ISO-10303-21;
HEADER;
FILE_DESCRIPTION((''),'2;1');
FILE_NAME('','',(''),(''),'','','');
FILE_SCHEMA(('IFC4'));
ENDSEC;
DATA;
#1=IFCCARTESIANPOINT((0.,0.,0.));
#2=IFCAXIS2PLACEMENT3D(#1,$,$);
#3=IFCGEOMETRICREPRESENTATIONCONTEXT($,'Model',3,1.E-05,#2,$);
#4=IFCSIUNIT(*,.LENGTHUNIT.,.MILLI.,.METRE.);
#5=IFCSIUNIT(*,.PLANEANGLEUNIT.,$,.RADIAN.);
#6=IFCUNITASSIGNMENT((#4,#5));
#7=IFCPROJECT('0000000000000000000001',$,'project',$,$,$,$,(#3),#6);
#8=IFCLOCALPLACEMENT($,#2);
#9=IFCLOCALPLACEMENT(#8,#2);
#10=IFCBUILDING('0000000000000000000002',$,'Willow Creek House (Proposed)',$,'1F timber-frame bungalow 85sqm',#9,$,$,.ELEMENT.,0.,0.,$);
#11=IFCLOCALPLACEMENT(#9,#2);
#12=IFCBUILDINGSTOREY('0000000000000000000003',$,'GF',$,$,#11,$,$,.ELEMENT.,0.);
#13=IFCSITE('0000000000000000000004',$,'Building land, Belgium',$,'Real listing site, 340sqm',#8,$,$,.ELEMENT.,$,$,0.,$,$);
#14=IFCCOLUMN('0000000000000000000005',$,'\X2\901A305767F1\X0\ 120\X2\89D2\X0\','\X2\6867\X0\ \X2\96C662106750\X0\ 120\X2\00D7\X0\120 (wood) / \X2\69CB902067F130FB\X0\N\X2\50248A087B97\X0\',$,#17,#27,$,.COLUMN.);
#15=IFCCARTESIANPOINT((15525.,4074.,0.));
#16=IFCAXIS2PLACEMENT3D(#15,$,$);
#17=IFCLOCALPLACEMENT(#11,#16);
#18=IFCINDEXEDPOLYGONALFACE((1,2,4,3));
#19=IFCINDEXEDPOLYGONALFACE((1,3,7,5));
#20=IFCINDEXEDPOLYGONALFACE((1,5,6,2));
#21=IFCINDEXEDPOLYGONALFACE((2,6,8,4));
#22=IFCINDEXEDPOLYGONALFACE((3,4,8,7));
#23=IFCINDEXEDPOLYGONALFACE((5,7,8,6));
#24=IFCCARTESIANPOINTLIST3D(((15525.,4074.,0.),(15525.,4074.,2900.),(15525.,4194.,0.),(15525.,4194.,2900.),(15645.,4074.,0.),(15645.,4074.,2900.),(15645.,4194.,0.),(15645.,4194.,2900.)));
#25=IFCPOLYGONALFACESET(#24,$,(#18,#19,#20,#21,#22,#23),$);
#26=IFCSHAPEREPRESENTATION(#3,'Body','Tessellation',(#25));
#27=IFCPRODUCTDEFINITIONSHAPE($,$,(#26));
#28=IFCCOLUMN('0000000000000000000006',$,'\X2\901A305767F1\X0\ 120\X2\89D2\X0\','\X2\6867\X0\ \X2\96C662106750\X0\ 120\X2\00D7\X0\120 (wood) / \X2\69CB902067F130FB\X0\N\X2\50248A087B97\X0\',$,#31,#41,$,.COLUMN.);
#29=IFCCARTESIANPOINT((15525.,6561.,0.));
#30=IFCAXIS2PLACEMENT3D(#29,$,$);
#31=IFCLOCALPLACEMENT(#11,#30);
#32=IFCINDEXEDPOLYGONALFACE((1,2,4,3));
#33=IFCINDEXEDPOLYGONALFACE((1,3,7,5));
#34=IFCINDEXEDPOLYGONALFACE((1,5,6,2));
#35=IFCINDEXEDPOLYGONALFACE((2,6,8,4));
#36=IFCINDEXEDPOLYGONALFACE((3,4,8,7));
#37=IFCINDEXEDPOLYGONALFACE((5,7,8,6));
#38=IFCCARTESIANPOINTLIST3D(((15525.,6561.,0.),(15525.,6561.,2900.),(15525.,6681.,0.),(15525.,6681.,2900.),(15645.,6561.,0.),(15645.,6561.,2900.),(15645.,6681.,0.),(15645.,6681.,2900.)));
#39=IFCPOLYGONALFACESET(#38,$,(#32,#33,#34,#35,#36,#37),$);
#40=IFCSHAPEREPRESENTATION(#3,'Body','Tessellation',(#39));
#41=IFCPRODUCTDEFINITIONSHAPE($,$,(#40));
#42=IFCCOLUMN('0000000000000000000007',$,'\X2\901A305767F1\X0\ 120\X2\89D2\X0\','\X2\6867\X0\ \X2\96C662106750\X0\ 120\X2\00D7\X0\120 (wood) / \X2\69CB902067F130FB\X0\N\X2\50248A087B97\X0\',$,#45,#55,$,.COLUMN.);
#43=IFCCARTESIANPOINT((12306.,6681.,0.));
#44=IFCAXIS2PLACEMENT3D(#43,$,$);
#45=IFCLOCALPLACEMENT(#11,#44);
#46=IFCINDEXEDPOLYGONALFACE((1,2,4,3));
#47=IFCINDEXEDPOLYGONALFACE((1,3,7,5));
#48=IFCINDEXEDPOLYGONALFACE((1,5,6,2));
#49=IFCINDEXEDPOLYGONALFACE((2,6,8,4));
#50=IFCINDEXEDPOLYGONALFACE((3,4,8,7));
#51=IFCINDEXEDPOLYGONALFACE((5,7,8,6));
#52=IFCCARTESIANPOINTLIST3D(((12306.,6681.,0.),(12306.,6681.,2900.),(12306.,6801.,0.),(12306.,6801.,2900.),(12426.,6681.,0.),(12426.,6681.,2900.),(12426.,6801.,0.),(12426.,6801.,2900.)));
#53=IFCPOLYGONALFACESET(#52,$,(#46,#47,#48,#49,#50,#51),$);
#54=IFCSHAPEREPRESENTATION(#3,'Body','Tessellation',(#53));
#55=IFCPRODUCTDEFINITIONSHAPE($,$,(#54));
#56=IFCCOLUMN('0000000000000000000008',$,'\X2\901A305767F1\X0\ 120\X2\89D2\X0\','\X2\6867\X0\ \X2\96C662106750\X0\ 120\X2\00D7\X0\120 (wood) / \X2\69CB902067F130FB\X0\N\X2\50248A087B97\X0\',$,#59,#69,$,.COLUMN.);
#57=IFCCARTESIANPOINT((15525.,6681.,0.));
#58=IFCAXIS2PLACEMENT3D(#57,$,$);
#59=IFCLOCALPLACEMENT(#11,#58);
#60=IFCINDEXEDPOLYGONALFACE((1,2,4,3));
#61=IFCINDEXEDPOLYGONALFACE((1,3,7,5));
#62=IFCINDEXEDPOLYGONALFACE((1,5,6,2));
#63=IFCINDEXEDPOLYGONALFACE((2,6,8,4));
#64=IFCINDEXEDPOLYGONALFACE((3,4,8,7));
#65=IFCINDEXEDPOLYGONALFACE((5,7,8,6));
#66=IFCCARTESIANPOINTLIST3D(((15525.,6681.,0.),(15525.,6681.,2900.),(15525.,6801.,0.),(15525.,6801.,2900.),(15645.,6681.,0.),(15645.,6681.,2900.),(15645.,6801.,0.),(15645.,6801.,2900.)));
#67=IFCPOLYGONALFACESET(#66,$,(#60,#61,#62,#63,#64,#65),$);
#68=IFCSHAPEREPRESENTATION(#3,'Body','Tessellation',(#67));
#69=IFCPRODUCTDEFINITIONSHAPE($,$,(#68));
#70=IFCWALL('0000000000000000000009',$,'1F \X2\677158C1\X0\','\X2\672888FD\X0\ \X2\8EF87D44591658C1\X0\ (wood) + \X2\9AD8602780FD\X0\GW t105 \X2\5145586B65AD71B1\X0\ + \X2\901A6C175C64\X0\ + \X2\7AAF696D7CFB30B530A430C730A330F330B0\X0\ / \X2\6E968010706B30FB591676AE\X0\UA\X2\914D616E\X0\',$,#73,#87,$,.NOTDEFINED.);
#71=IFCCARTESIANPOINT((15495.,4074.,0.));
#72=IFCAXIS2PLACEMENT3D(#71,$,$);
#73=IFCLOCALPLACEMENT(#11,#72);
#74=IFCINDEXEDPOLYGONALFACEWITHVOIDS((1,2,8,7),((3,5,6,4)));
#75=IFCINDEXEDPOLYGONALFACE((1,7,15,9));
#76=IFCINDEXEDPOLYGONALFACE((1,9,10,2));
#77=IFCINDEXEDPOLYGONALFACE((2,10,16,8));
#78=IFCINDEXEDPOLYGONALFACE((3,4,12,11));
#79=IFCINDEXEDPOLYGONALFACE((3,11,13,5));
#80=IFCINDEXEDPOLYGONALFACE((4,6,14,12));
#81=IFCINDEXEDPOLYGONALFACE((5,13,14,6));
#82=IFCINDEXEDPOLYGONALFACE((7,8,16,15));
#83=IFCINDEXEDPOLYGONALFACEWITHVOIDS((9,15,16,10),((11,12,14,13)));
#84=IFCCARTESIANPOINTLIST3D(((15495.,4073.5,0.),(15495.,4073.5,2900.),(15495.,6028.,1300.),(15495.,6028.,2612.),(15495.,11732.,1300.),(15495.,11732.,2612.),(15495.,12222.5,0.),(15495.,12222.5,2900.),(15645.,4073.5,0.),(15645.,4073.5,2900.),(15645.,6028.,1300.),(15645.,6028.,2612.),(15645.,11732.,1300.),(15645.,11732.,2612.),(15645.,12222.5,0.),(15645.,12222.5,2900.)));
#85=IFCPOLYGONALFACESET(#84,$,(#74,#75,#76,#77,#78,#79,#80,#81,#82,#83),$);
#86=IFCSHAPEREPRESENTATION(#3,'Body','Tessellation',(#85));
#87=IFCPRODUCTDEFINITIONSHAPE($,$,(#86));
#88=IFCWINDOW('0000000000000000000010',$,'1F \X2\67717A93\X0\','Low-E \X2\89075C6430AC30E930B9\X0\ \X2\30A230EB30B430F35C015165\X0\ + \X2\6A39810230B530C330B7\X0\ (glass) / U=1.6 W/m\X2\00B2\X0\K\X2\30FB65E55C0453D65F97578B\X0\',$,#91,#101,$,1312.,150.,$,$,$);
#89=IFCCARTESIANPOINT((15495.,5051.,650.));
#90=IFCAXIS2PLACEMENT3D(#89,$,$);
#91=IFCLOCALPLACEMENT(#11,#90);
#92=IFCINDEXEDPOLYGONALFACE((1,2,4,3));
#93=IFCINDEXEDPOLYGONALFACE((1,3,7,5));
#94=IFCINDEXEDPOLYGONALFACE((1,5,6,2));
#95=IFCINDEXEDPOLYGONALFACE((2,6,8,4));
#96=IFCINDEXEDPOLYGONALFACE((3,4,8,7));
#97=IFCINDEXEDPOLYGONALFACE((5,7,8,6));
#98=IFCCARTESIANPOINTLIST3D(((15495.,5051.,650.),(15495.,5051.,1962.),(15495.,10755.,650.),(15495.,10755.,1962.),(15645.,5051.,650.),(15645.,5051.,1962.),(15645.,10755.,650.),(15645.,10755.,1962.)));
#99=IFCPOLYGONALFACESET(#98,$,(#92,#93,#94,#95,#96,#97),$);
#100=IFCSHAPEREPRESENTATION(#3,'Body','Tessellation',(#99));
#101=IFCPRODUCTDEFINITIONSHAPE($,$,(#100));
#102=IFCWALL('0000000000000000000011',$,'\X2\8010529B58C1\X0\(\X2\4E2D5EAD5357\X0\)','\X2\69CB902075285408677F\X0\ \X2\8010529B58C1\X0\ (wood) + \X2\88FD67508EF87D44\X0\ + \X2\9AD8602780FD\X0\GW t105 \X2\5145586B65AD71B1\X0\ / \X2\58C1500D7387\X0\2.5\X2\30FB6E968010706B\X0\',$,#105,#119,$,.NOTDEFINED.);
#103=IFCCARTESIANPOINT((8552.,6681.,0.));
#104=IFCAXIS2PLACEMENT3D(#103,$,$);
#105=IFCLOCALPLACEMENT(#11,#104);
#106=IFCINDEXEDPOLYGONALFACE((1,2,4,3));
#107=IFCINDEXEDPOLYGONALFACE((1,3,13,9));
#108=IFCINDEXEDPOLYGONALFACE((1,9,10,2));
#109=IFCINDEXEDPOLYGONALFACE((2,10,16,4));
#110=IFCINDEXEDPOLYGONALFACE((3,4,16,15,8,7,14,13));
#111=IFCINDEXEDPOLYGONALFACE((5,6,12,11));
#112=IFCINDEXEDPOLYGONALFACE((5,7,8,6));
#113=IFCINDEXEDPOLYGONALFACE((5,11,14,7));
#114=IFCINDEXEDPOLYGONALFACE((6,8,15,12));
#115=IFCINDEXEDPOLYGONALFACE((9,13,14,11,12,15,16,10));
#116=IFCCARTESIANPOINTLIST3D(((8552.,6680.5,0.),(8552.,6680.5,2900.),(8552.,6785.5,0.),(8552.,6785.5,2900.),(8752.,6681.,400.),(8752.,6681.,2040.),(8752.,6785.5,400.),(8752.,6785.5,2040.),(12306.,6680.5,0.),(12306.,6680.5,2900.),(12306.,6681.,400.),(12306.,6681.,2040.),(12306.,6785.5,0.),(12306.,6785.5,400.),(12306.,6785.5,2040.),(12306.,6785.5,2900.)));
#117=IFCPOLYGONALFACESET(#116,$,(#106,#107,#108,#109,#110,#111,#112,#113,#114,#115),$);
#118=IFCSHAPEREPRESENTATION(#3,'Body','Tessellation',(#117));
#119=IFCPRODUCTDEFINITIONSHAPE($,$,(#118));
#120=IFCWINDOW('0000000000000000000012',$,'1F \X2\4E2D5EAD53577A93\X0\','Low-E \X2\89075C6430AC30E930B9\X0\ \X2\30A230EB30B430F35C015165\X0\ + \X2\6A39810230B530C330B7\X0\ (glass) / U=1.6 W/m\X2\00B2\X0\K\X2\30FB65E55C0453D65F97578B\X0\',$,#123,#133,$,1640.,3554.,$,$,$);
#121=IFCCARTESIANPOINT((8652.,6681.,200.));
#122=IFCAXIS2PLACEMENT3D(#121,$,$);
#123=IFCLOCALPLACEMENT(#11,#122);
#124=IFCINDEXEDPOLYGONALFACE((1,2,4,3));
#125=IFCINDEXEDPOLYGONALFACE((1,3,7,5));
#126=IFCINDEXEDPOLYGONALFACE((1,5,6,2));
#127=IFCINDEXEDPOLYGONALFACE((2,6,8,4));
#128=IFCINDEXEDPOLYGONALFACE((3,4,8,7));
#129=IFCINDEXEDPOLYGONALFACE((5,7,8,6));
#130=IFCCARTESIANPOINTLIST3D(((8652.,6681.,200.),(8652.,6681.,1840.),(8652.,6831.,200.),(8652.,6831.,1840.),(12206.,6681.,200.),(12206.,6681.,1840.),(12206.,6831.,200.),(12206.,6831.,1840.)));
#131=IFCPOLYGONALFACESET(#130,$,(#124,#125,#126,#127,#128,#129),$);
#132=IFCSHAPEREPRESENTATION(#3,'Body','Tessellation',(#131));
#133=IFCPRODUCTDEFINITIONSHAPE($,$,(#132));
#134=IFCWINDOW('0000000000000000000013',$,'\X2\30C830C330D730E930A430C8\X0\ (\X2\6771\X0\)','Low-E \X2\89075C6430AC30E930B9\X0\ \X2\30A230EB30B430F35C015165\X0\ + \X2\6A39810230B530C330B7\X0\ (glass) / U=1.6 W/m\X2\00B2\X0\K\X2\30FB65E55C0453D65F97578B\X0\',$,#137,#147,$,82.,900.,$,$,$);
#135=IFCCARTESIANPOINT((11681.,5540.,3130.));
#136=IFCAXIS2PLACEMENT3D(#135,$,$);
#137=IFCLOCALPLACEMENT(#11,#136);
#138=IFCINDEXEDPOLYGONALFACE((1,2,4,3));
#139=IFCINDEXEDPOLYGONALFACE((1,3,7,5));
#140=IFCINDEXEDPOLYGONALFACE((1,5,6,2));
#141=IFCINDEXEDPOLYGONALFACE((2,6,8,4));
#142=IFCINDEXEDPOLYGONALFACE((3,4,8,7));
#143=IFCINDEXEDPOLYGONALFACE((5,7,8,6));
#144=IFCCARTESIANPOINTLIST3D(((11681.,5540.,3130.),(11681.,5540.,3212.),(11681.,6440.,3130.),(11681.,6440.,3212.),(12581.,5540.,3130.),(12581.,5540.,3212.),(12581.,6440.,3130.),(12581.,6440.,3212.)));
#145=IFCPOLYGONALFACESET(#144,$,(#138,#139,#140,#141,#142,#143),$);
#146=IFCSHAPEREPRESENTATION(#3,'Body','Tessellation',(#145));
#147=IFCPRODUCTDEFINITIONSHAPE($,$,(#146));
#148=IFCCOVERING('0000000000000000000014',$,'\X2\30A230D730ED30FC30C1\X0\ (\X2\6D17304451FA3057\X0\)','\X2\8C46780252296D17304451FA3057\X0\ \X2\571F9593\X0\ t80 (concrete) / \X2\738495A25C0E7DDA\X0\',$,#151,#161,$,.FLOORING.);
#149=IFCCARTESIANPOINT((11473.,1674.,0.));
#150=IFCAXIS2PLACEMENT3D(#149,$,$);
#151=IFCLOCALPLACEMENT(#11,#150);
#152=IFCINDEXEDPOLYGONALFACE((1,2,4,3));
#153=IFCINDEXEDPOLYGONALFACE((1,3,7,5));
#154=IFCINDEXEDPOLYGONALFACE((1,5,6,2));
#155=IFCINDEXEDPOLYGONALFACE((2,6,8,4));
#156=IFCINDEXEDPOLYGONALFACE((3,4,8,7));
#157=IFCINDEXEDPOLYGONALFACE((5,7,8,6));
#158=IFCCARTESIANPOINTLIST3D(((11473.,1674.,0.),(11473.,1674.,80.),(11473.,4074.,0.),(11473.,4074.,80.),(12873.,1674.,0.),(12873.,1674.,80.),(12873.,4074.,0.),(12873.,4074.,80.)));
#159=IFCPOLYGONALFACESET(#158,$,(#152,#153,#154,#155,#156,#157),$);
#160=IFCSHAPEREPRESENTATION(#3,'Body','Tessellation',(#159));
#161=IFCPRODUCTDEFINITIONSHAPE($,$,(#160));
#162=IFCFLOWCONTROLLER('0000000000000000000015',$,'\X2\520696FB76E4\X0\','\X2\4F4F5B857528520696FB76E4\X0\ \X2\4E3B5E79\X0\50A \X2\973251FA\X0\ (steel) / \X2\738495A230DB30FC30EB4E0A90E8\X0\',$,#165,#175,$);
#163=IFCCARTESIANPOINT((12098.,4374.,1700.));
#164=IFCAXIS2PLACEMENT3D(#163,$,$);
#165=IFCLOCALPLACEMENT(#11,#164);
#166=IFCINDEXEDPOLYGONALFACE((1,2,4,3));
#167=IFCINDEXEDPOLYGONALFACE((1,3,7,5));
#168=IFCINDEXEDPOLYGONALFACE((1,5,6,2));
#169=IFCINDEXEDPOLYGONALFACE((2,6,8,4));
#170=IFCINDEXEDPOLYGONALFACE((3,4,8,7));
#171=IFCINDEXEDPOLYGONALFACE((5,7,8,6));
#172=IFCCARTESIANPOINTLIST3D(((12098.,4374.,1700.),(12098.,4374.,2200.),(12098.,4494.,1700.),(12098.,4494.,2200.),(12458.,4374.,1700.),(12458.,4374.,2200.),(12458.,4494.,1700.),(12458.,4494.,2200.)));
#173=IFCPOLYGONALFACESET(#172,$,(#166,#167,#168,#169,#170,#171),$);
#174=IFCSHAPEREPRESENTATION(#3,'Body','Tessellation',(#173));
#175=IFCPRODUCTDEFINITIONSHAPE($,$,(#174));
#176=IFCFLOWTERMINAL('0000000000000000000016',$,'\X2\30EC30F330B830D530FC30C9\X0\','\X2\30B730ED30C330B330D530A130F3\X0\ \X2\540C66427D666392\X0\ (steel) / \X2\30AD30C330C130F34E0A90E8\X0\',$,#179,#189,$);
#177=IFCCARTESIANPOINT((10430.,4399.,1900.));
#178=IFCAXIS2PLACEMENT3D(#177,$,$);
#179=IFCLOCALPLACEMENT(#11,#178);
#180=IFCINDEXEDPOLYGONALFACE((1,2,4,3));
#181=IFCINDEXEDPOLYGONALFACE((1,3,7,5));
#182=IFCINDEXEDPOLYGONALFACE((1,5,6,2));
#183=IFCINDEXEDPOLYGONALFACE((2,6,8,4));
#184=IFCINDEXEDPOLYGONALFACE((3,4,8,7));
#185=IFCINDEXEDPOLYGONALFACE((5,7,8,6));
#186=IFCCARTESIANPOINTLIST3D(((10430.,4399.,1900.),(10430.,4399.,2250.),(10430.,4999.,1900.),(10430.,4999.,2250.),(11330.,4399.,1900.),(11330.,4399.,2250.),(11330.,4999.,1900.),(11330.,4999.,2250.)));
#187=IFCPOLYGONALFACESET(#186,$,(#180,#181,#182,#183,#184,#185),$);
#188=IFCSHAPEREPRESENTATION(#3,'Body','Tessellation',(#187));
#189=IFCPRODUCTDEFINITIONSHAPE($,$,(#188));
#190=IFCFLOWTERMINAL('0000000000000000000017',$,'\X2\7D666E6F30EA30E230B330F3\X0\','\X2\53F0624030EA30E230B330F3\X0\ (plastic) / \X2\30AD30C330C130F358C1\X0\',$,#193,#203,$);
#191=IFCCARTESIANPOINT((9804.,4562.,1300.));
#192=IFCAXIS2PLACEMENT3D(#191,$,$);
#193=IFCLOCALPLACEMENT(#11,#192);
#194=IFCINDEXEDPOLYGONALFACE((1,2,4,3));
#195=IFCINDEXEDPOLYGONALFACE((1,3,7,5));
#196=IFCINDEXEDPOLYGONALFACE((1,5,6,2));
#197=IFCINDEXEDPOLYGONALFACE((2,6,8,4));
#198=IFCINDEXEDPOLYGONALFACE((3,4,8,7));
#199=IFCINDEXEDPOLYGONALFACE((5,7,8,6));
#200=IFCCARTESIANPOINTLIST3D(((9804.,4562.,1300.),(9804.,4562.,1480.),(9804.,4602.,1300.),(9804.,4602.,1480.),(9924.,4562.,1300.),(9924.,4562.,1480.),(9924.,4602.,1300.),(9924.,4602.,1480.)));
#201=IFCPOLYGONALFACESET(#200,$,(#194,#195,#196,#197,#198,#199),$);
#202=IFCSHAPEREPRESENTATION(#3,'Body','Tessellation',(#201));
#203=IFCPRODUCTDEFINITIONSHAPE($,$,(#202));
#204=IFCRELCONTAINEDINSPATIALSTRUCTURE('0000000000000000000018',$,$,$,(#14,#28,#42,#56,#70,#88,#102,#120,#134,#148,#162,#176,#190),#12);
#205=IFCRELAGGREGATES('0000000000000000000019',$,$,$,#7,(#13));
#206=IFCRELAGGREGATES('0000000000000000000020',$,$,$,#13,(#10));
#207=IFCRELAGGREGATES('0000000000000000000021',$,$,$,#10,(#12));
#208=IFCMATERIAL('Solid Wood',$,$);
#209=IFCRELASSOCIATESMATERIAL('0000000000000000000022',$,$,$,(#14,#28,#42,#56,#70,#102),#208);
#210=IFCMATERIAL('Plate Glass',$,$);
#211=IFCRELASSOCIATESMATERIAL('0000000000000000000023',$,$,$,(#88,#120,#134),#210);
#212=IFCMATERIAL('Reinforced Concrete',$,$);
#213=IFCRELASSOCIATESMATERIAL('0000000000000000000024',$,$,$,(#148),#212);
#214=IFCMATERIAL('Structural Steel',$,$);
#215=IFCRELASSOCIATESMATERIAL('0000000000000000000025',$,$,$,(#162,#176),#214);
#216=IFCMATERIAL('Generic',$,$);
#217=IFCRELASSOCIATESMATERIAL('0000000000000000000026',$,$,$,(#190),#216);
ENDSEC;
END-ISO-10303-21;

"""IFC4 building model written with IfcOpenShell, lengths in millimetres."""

from ifc_helpers import new_model, si_unit, frame, frame_2d, origin, place, context, project, spatial, rectangle, extrude, material, element, fill, save


model = new_model("IFC4")

# Units and contexts
model_context = context("Model", 3, precision=1e-05, world=origin())
ifc_project = project(units=[si_unit("LENGTHUNIT", "METRE", prefix="MILLI"), si_unit("PLANEANGLEUNIT", "RADIAN")], contexts=[model_context])

# Site, building, storey
site_placement = place(None, origin())
site = spatial("IfcSite", under=ifc_project, at=site_placement, Name="Building land, Belgium", ObjectType="Real listing site, 340sqm", CompositionType="ELEMENT", RefElevation=0.0)
building_placement = place(site_placement, origin())
building = spatial("IfcBuilding", under=site, at=building_placement, Name="Willow Creek House (Proposed)", ObjectType="1F timber-frame bungalow 85sqm", CompositionType="ELEMENT", ElevationOfRefHeight=0.0, ElevationOfTerrain=0.0)
storey_placement = place(building_placement, origin())
storey = spatial("IfcBuildingStorey", under=building, at=storey_placement, Name="GF", CompositionType="ELEMENT", Elevation=0.0)

# Columns
ifc_material_1 = material(Name="Solid Wood")
column_1_placement = place(storey_placement, frame((15525.0, 4074.0, 0.0)))
element("IfcColumn", 1, at=column_1_placement, inside=storey, material=ifc_material_1, Name="通し柱 120角", Description="桧 集成材 120×120 (wood) / 構造柱・N値計算", PredefinedType="COLUMN", context=model_context, shape_type="SweptSolid", body=[
    extrude(rectangle(XDim=120.0, YDim=120.0, at=frame_2d((60.0, 60.0))), frame((15525.0, 4074.0, 0.0)), (0.0, 0.0, 1.0), 2900.0),
])
column_2_placement = place(storey_placement, frame((15525.0, 6561.0, 0.0)))
element("IfcColumn", 2, at=column_2_placement, inside=storey, material=ifc_material_1, Name="通し柱 120角", Description="桧 集成材 120×120 (wood) / 構造柱・N値計算", PredefinedType="COLUMN", context=model_context, shape_type="SweptSolid", body=[
    extrude(rectangle(XDim=120.0, YDim=120.0, at=frame_2d((60.0, 60.0))), frame((15525.0, 6561.0, 0.0)), (0.0, 0.0, 1.0), 2900.0),
])
column_3_placement = place(storey_placement, frame((12306.0, 6681.0, 0.0)))
element("IfcColumn", 3, at=column_3_placement, inside=storey, material=ifc_material_1, Name="通し柱 120角", Description="桧 集成材 120×120 (wood) / 構造柱・N値計算", PredefinedType="COLUMN", context=model_context, shape_type="SweptSolid", body=[
    extrude(rectangle(XDim=120.0, YDim=120.0, at=frame_2d((60.0, 60.0))), frame((12306.0, 6681.0, 0.0)), (0.0, 0.0, 1.0), 2900.0),
])
column_4_placement = place(storey_placement, frame((15525.0, 6681.0, 0.0)))
element("IfcColumn", 4, at=column_4_placement, inside=storey, material=ifc_material_1, Name="通し柱 120角", Description="桧 集成材 120×120 (wood) / 構造柱・N値計算", PredefinedType="COLUMN", context=model_context, shape_type="SweptSolid", body=[
    extrude(rectangle(XDim=120.0, YDim=120.0, at=frame_2d((60.0, 60.0))), frame((15525.0, 6681.0, 0.0)), (0.0, 0.0, 1.0), 2900.0),
])

# Walls, openings, windows
wall_1_placement = place(storey_placement, frame((15495.0, 4074.0, 0.0)))
wall_1 = element("IfcWall", 5, at=wall_1_placement, inside=storey, material=ifc_material_1, Name="1F 東壁", Description="木製 軸組外壁 (wood) + 高性能GW t105 充填断熱 + 通気層 + 窯業系サイディング / 準耐火・外皮UA配慮", PredefinedType="NOTDEFINED", context=model_context, shape_type="SweptSolid", body=[
    extrude(rectangle(XDim=150.0, YDim=8149.0, at=frame_2d((75.0, 4074.0))), frame((15495.0, 4074.0, 0.0)), (0.0, 0.0, 1.0), 2900.0),
])
opening_1_placement = place(storey_placement, frame((15495.0, 5051.0, 650.0)))
opening_1 = element("IfcOpeningElement", 6, at=opening_1_placement, cuts=wall_1, PredefinedType="NOTDEFINED", context=model_context, shape_type="SweptSolid", body=[
    extrude(rectangle(XDim=150.0, YDim=5704.0, at=frame_2d((75.0, 2852.0))), frame((15495.0, 5051.0, 650.0)), (0.0, 0.0, 1.0), 1312.0),
])
ifc_material_2 = material(Name="Plate Glass")
window_1_placement = place(storey_placement, frame((15495.0, 5051.0, 650.0)))
window_1 = element("IfcWindow", 7, at=window_1_placement, inside=storey, material=ifc_material_2, Name="1F 東窓", Description="Low-E 複層ガラス アルゴン封入 + 樹脂サッシ (glass) / U=1.6 W/m²K・日射取得型", OverallHeight=1312.0, OverallWidth=150.0, context=model_context, shape_type="SweptSolid", body=[
    extrude(rectangle(XDim=150.0, YDim=5704.0, at=frame_2d((75.0, 2852.0))), frame((15495.0, 5051.0, 650.0)), (0.0, 0.0, 1.0), 1312.0),
])
fill(opening_1, window_1)
wall_2_placement = place(storey_placement, frame((8552.0, 6681.0, 0.0)))
wall_2 = element("IfcWall", 8, at=wall_2_placement, inside=storey, material=ifc_material_1, Name="耐力壁(中庭南)", Description="構造用合板 耐力壁 (wood) + 製材軸組 + 高性能GW t105 充填断熱 / 壁倍率2.5・準耐火", PredefinedType="NOTDEFINED", context=model_context, shape_type="SweptSolid", body=[
    extrude(rectangle(XDim=3754.0, YDim=105.0, at=frame_2d((1877.0, 52.0))), frame((8552.0, 6681.0, 0.0)), (0.0, 0.0, 1.0), 2900.0),
])
opening_2_placement = place(storey_placement, frame((8652.0, 6681.0, 200.0)))
opening_2 = element("IfcOpeningElement", 9, at=opening_2_placement, cuts=wall_2, PredefinedType="NOTDEFINED", context=model_context, shape_type="SweptSolid", body=[
    extrude(rectangle(XDim=3554.0, YDim=150.0, at=frame_2d((1777.0, 75.0))), frame((8652.0, 6681.0, 200.0)), (0.0, 0.0, 1.0), 1640.0),
])
window_2_placement = place(storey_placement, frame((8652.0, 6681.0, 200.0)))
window_2 = element("IfcWindow", 10, at=window_2_placement, inside=storey, material=ifc_material_2, Name="1F 中庭南窓", Description="Low-E 複層ガラス アルゴン封入 + 樹脂サッシ (glass) / U=1.6 W/m²K・日射取得型", OverallHeight=1640.0, OverallWidth=3554.0, context=model_context, shape_type="SweptSolid", body=[
    extrude(rectangle(XDim=3554.0, YDim=150.0, at=frame_2d((1777.0, 75.0))), frame((8652.0, 6681.0, 200.0)), (0.0, 0.0, 1.0), 1640.0),
])
fill(opening_2, window_2)

# Window
window_3_placement = place(storey_placement, frame((11681.0, 5540.0, 3130.0)))
element("IfcWindow", 11, at=window_3_placement, inside=storey, material=ifc_material_2, Name="トップライト (東)", Description="Low-E 複層ガラス アルゴン封入 + 樹脂サッシ (glass) / U=1.6 W/m²K・日射取得型", OverallHeight=82.0, OverallWidth=900.0, context=model_context, shape_type="SweptSolid", body=[
    extrude(rectangle(XDim=900.0, YDim=900.0, at=frame_2d((450.0, 450.0))), frame((11681.0, 5540.0, 3130.0)), (0.0, 0.0, 1.0), 82.0),
])

# Shared definitions
ifc_material_3 = material(Name="Structural Steel")

# Covering
ifc_material_4 = material(Name="Reinforced Concrete")
covering_placement = place(storey_placement, frame((11473.0, 1674.0, 0.0)))
element("IfcCovering", 12, at=covering_placement, inside=storey, material=ifc_material_4, Name="アプローチ (洗い出し)", Description="豆砂利洗い出し 土間 t80 (concrete) / 玄関導線", PredefinedType="FLOORING", context=model_context, shape_type="SweptSolid", body=[
    extrude(rectangle(XDim=1400.0, YDim=2400.0, at=frame_2d((700.0, 1200.0))), frame((11473.0, 1674.0, 0.0)), (0.0, 0.0, 1.0), 80.0),
])

# Flow controller
flow_controller_placement = place(storey_placement, frame((12098.0, 4374.0, 1700.0)))
element("IfcFlowController", 13, at=flow_controller_placement, inside=storey, material=ifc_material_3, Name="分電盤", Description="住宅用分電盤 主幹50A 露出 (steel) / 玄関ホール上部", context=model_context, shape_type="SweptSolid", body=[
    extrude(rectangle(XDim=360.0, YDim=120.0, at=frame_2d((180.0, 60.0))), frame((12098.0, 4374.0, 1700.0)), (0.0, 0.0, 1.0), 500.0),
])

# Flow terminals
flow_terminal_1_placement = place(storey_placement, frame((10430.0, 4399.0, 1900.0)))
element("IfcFlowTerminal", 14, at=flow_terminal_1_placement, inside=storey, material=ifc_material_3, Name="レンジフード", Description="シロッコファン 同時給排 (steel) / キッチン上部", context=model_context, shape_type="SweptSolid", body=[
    extrude(rectangle(XDim=900.0, YDim=600.0, at=frame_2d((450.0, 300.0))), frame((10430.0, 4399.0, 1900.0)), (0.0, 0.0, 1.0), 350.0),
])
ifc_material_5 = material(Name="Generic")
flow_terminal_2_placement = place(storey_placement, frame((9804.0, 4562.0, 1300.0)))
element("IfcFlowTerminal", 15, at=flow_terminal_2_placement, inside=storey, material=ifc_material_5, Name="給湯リモコン", Description="台所リモコン (plastic) / キッチン壁", context=model_context, shape_type="SweptSolid", body=[
    extrude(rectangle(XDim=120.0, YDim=40.0, at=frame_2d((60.0, 20.0))), frame((9804.0, 4562.0, 1300.0)), (0.0, 0.0, 1.0), 180.0),
])

save(model, "model.ifc")
